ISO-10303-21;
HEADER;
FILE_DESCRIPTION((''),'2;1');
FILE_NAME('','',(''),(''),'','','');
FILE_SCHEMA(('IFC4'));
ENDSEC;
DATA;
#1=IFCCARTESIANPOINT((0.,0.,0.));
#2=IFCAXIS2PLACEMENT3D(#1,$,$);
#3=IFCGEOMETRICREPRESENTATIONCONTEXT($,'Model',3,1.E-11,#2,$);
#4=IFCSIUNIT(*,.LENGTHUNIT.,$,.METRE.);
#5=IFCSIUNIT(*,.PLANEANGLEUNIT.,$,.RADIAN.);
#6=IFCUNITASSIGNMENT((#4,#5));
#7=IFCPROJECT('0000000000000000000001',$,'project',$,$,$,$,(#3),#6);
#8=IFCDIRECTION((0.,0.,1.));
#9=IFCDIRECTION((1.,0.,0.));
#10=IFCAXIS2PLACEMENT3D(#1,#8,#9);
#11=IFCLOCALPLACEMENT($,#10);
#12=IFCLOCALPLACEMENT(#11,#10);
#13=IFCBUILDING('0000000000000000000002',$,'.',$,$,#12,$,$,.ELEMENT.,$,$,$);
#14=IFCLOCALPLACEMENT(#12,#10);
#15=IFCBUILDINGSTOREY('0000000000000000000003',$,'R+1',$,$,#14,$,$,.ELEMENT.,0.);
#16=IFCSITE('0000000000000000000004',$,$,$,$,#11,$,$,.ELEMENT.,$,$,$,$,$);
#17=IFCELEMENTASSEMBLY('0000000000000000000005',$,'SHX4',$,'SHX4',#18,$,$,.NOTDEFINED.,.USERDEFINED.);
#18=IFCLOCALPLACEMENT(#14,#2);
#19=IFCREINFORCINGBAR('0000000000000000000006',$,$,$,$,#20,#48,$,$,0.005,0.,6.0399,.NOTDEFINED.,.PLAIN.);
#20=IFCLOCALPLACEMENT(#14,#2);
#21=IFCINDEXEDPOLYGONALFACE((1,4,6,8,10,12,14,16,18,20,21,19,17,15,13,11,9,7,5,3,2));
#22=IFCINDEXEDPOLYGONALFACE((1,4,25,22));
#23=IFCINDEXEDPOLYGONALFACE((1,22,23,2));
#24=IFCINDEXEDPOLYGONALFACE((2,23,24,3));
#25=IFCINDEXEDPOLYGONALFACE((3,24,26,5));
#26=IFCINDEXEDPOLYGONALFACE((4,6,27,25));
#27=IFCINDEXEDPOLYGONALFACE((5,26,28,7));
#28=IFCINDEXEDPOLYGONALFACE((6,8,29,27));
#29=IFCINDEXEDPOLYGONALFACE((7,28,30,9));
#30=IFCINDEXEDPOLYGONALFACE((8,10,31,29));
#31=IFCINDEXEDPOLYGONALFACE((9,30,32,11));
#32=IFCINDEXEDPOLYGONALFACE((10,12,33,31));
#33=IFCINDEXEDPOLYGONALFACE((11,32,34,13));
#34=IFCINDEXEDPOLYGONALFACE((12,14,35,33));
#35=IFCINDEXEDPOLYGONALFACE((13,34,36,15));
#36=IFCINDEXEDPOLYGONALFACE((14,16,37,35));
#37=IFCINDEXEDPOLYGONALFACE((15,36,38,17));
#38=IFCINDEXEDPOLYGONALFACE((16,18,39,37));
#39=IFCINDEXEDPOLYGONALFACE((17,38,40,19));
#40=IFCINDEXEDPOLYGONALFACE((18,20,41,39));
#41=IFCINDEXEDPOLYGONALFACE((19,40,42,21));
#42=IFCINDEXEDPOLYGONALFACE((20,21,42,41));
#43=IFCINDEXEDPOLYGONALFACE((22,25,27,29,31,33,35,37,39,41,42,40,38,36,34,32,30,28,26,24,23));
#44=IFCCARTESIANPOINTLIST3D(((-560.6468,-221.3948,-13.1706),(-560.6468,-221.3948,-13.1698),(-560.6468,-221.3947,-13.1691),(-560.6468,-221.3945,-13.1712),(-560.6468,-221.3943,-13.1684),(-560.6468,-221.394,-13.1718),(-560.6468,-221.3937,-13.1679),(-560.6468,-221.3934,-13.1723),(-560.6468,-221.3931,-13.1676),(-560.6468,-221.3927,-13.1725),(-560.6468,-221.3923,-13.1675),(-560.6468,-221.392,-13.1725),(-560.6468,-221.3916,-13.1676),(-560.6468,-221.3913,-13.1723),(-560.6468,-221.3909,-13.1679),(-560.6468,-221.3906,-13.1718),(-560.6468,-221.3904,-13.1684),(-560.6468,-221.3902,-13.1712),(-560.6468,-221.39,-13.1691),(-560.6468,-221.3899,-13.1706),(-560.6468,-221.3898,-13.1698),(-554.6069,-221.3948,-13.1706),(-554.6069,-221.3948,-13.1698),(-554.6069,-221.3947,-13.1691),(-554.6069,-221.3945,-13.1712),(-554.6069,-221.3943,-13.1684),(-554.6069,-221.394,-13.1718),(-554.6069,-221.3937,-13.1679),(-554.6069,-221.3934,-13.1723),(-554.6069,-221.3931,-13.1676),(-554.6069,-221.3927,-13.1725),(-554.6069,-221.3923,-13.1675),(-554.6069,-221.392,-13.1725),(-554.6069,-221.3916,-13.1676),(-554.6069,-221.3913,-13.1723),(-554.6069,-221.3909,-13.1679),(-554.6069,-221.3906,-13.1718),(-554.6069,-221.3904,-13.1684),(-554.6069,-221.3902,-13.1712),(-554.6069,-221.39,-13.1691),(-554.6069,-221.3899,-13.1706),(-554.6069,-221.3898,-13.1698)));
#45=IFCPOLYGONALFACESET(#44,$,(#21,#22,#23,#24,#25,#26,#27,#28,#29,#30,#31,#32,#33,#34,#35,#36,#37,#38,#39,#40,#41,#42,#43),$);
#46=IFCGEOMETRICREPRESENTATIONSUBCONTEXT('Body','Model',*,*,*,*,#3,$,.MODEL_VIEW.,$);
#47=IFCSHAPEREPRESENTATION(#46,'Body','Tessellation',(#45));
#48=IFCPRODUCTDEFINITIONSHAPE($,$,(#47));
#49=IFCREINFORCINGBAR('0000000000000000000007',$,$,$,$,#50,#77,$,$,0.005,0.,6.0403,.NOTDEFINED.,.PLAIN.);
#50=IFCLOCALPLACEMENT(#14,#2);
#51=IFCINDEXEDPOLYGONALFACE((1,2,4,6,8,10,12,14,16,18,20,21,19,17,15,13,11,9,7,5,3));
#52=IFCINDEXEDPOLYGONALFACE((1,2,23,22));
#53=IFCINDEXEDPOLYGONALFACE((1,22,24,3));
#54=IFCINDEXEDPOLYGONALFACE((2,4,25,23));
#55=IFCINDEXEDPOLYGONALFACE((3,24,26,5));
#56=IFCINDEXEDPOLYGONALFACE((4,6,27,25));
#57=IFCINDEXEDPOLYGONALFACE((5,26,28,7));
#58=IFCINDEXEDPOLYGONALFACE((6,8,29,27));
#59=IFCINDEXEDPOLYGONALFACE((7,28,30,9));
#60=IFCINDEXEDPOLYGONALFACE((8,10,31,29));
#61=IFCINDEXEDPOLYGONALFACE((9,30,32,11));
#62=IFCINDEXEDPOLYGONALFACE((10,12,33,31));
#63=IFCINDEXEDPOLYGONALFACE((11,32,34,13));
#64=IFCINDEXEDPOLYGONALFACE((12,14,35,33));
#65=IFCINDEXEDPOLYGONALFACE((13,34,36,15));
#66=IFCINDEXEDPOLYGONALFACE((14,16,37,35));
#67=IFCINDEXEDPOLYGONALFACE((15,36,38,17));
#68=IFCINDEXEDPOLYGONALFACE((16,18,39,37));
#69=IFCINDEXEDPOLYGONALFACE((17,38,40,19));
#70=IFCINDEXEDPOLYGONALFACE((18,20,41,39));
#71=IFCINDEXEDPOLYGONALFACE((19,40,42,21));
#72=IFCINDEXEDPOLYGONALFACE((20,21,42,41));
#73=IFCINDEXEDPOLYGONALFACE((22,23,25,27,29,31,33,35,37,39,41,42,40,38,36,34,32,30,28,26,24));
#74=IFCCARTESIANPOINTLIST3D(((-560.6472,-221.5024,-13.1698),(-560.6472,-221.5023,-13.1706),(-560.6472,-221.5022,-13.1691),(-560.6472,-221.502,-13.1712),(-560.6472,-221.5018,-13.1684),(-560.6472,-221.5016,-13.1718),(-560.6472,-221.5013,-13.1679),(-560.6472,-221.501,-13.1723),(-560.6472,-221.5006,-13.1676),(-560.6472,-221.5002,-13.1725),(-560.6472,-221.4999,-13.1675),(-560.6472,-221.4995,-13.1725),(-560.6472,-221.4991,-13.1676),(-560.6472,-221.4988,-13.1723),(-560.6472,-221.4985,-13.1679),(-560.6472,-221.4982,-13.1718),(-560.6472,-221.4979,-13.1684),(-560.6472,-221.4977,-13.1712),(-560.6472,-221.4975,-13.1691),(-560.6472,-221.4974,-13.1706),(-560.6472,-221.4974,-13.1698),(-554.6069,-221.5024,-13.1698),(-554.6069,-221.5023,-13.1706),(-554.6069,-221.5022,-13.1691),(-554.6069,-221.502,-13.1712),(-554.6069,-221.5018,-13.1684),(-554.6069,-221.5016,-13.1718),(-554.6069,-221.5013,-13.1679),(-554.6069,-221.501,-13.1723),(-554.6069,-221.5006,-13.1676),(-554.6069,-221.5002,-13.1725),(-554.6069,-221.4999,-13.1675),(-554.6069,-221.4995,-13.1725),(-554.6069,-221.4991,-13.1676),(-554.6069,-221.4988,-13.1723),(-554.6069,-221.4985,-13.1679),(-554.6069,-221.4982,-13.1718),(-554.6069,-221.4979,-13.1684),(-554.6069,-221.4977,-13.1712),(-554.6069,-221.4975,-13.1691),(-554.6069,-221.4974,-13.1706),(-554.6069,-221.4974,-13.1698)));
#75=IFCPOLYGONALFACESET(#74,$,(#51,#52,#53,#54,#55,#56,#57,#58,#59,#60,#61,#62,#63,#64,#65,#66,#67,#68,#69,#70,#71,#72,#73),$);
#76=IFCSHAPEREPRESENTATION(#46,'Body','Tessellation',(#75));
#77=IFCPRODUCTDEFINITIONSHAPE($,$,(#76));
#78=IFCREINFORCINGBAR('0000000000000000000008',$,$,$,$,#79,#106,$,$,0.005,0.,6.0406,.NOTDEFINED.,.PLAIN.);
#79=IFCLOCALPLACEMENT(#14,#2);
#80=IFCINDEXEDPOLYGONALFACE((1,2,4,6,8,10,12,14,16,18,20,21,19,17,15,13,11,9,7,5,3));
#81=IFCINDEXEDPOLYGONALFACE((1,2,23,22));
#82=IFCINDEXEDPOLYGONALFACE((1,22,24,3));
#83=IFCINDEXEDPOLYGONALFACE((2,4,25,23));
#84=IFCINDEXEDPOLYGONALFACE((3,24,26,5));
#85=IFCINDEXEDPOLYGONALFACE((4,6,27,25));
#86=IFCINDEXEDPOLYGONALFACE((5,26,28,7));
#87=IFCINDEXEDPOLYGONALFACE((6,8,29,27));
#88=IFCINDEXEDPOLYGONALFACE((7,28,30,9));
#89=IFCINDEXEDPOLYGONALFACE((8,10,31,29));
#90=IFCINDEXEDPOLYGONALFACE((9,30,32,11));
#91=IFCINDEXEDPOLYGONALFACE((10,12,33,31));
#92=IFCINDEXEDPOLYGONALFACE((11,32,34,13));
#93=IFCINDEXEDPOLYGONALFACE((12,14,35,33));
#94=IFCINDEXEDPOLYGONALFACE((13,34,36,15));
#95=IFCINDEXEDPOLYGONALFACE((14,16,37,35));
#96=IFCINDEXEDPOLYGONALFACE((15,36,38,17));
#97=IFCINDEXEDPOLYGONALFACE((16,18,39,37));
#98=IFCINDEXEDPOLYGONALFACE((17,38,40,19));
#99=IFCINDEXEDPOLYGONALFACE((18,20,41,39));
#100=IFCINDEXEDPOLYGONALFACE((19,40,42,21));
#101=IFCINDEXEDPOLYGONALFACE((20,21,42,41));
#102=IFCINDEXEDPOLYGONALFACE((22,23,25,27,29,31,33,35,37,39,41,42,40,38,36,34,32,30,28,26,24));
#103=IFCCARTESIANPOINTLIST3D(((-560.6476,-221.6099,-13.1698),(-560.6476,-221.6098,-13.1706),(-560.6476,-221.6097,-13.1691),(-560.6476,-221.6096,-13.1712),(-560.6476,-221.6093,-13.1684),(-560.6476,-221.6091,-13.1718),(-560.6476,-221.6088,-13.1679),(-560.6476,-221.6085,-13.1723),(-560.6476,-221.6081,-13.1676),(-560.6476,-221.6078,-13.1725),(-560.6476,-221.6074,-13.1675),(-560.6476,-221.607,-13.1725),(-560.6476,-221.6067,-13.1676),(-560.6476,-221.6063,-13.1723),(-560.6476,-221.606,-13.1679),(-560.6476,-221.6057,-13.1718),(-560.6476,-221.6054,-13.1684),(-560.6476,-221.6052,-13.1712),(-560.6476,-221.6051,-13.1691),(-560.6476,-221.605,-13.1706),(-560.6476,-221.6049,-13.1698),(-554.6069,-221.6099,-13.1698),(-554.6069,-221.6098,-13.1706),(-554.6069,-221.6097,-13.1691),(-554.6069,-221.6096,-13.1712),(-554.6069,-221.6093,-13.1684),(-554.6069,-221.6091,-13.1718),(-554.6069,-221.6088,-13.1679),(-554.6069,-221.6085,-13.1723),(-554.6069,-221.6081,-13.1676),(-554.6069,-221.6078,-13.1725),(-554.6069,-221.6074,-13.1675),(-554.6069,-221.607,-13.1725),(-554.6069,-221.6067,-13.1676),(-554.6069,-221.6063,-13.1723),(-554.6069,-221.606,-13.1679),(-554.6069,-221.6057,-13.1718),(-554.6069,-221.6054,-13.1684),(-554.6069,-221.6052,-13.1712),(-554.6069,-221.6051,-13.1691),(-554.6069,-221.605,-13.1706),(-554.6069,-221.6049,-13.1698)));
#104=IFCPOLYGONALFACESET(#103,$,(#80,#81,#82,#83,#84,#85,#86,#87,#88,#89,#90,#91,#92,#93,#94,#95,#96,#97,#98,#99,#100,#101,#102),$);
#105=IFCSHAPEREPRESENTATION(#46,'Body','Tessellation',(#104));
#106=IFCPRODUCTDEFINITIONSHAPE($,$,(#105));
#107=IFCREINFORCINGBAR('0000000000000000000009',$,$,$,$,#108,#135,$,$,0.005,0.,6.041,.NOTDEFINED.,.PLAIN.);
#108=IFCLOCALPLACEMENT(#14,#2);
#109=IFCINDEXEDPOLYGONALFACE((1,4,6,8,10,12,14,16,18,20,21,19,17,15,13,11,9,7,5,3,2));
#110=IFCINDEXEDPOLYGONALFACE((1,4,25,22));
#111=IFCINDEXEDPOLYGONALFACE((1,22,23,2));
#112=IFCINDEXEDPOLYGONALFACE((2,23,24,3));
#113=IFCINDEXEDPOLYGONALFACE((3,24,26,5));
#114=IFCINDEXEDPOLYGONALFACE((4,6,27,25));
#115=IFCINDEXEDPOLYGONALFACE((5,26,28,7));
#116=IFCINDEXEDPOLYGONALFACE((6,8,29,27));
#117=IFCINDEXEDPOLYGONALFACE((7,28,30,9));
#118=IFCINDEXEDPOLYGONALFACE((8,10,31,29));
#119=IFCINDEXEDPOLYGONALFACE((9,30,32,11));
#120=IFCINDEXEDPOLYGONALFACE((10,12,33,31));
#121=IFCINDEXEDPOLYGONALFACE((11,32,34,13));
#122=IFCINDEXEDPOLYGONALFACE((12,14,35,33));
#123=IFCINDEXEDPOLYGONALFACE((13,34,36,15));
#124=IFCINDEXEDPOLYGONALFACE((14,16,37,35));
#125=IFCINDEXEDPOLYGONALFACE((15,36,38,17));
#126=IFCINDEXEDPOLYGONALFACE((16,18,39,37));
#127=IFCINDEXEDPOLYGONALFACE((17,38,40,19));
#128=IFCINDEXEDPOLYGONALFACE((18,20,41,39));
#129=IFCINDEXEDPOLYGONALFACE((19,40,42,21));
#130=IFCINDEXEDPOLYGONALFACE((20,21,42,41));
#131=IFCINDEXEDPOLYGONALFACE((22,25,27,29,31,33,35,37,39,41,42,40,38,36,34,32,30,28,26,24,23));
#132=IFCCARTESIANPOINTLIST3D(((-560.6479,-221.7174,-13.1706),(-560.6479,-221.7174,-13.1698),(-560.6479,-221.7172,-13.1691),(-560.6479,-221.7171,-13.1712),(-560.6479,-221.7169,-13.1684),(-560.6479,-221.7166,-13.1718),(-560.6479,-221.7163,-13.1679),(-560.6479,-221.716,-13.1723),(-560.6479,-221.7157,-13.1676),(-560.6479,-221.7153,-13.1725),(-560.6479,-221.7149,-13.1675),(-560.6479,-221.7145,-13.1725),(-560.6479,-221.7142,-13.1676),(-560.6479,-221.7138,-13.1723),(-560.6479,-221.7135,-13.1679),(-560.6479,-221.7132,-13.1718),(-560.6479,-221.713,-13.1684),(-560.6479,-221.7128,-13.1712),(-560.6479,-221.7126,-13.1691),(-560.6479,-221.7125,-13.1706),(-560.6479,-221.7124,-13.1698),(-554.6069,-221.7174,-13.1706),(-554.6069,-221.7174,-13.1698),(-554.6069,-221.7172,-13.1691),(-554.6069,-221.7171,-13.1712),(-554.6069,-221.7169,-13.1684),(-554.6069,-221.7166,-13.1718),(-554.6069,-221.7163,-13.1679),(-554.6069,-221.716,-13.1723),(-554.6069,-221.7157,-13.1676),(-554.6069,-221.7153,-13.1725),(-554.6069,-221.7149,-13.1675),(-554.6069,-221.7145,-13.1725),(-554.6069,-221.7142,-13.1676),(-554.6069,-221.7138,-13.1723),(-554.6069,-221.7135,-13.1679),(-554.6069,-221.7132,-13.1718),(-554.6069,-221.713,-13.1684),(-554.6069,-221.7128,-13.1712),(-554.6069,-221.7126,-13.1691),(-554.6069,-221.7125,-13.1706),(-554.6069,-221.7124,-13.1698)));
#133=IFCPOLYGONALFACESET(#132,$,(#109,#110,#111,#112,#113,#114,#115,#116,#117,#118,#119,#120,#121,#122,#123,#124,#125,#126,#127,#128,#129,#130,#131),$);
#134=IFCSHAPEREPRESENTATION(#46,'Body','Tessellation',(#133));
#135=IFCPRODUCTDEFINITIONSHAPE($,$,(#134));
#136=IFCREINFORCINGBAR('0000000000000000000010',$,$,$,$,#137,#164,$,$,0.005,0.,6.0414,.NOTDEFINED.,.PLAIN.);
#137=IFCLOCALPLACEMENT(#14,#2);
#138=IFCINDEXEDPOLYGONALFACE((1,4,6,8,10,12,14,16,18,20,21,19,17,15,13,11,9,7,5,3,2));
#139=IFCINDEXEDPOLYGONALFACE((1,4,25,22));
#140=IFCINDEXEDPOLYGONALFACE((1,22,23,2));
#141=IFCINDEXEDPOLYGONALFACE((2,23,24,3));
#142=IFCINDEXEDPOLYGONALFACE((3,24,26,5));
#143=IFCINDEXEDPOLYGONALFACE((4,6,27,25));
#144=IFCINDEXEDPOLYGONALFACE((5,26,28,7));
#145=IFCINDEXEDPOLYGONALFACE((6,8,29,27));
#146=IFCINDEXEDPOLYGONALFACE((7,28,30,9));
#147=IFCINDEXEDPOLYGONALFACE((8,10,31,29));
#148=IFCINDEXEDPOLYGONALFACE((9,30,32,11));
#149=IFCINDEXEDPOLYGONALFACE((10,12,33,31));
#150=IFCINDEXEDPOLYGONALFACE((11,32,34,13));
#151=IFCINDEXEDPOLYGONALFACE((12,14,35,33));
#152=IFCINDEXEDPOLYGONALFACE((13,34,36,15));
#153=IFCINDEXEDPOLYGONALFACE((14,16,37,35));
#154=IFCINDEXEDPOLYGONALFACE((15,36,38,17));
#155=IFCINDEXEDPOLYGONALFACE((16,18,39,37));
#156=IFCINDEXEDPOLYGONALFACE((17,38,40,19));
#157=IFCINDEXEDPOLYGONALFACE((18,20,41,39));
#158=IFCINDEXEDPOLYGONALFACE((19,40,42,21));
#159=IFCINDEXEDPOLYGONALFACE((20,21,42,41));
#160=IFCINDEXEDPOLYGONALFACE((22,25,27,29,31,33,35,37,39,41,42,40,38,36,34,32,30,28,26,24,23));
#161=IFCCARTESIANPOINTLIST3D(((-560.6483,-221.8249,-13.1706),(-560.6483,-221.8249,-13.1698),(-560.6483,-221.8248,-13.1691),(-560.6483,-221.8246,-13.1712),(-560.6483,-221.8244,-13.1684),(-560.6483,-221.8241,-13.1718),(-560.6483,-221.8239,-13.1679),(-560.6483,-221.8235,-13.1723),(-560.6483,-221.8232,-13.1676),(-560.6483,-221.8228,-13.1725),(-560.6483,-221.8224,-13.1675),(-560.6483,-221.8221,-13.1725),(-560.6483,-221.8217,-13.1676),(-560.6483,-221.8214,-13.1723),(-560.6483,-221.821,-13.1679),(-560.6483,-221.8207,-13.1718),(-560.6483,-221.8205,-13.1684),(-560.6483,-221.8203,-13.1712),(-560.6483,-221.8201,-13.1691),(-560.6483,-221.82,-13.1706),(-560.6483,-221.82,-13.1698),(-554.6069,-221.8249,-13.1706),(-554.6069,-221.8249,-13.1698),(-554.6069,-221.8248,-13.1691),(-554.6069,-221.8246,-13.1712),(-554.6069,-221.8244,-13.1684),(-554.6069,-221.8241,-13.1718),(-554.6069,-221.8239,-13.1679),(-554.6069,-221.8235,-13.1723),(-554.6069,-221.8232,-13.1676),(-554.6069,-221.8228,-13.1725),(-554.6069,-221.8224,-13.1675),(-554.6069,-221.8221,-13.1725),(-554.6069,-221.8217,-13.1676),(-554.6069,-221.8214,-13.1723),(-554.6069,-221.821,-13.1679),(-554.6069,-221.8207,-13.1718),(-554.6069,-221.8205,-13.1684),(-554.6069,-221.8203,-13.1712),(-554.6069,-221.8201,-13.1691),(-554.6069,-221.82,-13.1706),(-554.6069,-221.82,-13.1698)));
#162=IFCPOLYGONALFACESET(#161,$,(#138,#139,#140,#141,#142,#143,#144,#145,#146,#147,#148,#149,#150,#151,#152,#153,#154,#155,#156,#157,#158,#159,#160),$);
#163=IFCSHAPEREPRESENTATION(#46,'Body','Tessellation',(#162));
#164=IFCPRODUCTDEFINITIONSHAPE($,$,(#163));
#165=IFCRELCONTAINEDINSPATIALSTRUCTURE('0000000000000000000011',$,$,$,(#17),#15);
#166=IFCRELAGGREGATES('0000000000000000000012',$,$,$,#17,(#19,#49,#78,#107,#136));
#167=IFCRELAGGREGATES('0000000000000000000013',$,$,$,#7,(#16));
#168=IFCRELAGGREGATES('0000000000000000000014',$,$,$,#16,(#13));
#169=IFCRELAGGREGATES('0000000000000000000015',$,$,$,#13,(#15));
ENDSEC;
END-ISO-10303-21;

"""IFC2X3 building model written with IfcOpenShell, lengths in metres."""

from ifc_helpers import new_model, entity, si_unit, origin, origin_with_axes, place, context, subcontext, project, spatial, shape, element, aggregate, save


model = new_model("IFC2X3")

# Units and contexts
model_context = context("Model", 3, precision=1e-11, world=origin())
body_context = subcontext(model_context, "Body", "Model", "MODEL_VIEW")
ifc_project = project(units=[si_unit("LENGTHUNIT", "METRE"), si_unit("PLANEANGLEUNIT", "RADIAN")], contexts=[model_context])

# Site, building, storey
site_placement = place(None, origin_with_axes())
site = spatial("IfcSite", under=ifc_project, at=site_placement, CompositionType="ELEMENT")
building_placement = place(site_placement, origin_with_axes())
building = spatial("IfcBuilding", under=site, at=building_placement, Name=".", CompositionType="ELEMENT")
storey_placement = place(building_placement, origin_with_axes())
storey = spatial("IfcBuildingStorey", under=building, at=storey_placement, Name="R+1", CompositionType="ELEMENT", Elevation=0.0)

# Element assembly, reinforcing bars
assembly_1_placement = place(storey_placement, origin_with_axes())
assembly_1 = element("IfcElementAssembly", 1, at=assembly_1_placement, inside=storey, Name="SHX4", ObjectType="SHX4", AssemblyPlace="NOTDEFINED", PredefinedType="USERDEFINED")
reinforcing_bar_1_placement = place(assembly_1_placement, origin_with_axes())
reinforcing_bar_1 = element("IfcReinforcingBar", 2, at=reinforcing_bar_1_placement, BarLength=6.0399, BarRole="NOTDEFINED", BarSurface="PLAIN", CrossSectionArea=0.0, NominalDiameter=0.005, shapes=[
    shape(body_context, "Body", "AdvancedSweptSolid", [entity("IfcSweptDiskSolid", entity("IfcPolyline", [entity("IfcCartesianPoint", [554.6069, 221.3923, 13.17]), entity("IfcCartesianPoint", [560.6468, 221.3923, 13.17])]), 0.0025, None, 0.0, 6.0399)]),
    shape(body_context, "Body", "AdvancedSweptSolid", [entity("IfcSweptDiskSolid", entity("IfcPolyline", [entity("IfcCartesianPoint", [554.6069, 221.3923, 13.17]), entity("IfcCartesianPoint", [560.6468, 221.3923, 13.17])]), 0.0025, None, 0.0, 6.0399)]),
])
reinforcing_bar_2_placement = place(assembly_1_placement, origin_with_axes())
reinforcing_bar_2 = element("IfcReinforcingBar", 3, at=reinforcing_bar_2_placement, BarLength=6.0403, BarRole="NOTDEFINED", BarSurface="PLAIN", CrossSectionArea=0.0, NominalDiameter=0.005, shapes=[
    shape(body_context, "Body", "AdvancedSweptSolid", [entity("IfcSweptDiskSolid", entity("IfcPolyline", [entity("IfcCartesianPoint", [554.6069, 221.4999, 13.17]), entity("IfcCartesianPoint", [560.6472, 221.4999, 13.17])]), 0.0025, None, 0.0, 6.0403)]),
    shape(body_context, "Body", "AdvancedSweptSolid", [entity("IfcSweptDiskSolid", entity("IfcPolyline", [entity("IfcCartesianPoint", [554.6069, 221.4999, 13.17]), entity("IfcCartesianPoint", [560.6472, 221.4999, 13.17])]), 0.0025, None, 0.0, 6.0403)]),
])
reinforcing_bar_3_placement = place(assembly_1_placement, origin_with_axes())
reinforcing_bar_3 = element("IfcReinforcingBar", 4, at=reinforcing_bar_3_placement, BarLength=6.0406, BarRole="NOTDEFINED", BarSurface="PLAIN", CrossSectionArea=0.0, NominalDiameter=0.005, shapes=[
    shape(body_context, "Body", "AdvancedSweptSolid", [entity("IfcSweptDiskSolid", entity("IfcPolyline", [entity("IfcCartesianPoint", [554.6069, 221.6074, 13.17]), entity("IfcCartesianPoint", [560.6476, 221.6074, 13.17])]), 0.0025, None, 0.0, 6.0406)]),
    shape(body_context, "Body", "AdvancedSweptSolid", [entity("IfcSweptDiskSolid", entity("IfcPolyline", [entity("IfcCartesianPoint", [554.6069, 221.6074, 13.17]), entity("IfcCartesianPoint", [560.6476, 221.6074, 13.17])]), 0.0025, None, 0.0, 6.0406)]),
])
reinforcing_bar_4_placement = place(assembly_1_placement, origin_with_axes())
reinforcing_bar_4 = element("IfcReinforcingBar", 5, at=reinforcing_bar_4_placement, BarLength=6.041, BarRole="NOTDEFINED", BarSurface="PLAIN", CrossSectionArea=0.0, NominalDiameter=0.005, shapes=[
    shape(body_context, "Body", "AdvancedSweptSolid", [entity("IfcSweptDiskSolid", entity("IfcPolyline", [entity("IfcCartesianPoint", [554.6069, 221.7149, 13.17]), entity("IfcCartesianPoint", [560.6479, 221.7149, 13.17])]), 0.0025, None, 0.0, 6.041)]),
    shape(body_context, "Body", "AdvancedSweptSolid", [entity("IfcSweptDiskSolid", entity("IfcPolyline", [entity("IfcCartesianPoint", [554.6069, 221.7149, 13.17]), entity("IfcCartesianPoint", [560.6479, 221.7149, 13.17])]), 0.0025, None, 0.0, 6.041)]),
])
reinforcing_bar_5_placement = place(assembly_1_placement, origin_with_axes())
reinforcing_bar_5 = element("IfcReinforcingBar", 6, at=reinforcing_bar_5_placement, BarLength=6.0414, BarRole="NOTDEFINED", BarSurface="PLAIN", CrossSectionArea=0.0, NominalDiameter=0.005, shapes=[
    shape(body_context, "Body", "AdvancedSweptSolid", [entity("IfcSweptDiskSolid", entity("IfcPolyline", [entity("IfcCartesianPoint", [554.6069, 221.8224, 13.17]), entity("IfcCartesianPoint", [560.6483, 221.8224, 13.17])]), 0.0025, None, 0.0, 6.0414)]),
    shape(body_context, "Body", "AdvancedSweptSolid", [entity("IfcSweptDiskSolid", entity("IfcPolyline", [entity("IfcCartesianPoint", [554.6069, 221.8224, 13.17]), entity("IfcCartesianPoint", [560.6483, 221.8224, 13.17])]), 0.0025, None, 0.0, 6.0414)]),
])
aggregate(assembly_1, [reinforcing_bar_1, reinforcing_bar_2, reinforcing_bar_3, reinforcing_bar_4, reinforcing_bar_5])

save(model, "model.ifc")
